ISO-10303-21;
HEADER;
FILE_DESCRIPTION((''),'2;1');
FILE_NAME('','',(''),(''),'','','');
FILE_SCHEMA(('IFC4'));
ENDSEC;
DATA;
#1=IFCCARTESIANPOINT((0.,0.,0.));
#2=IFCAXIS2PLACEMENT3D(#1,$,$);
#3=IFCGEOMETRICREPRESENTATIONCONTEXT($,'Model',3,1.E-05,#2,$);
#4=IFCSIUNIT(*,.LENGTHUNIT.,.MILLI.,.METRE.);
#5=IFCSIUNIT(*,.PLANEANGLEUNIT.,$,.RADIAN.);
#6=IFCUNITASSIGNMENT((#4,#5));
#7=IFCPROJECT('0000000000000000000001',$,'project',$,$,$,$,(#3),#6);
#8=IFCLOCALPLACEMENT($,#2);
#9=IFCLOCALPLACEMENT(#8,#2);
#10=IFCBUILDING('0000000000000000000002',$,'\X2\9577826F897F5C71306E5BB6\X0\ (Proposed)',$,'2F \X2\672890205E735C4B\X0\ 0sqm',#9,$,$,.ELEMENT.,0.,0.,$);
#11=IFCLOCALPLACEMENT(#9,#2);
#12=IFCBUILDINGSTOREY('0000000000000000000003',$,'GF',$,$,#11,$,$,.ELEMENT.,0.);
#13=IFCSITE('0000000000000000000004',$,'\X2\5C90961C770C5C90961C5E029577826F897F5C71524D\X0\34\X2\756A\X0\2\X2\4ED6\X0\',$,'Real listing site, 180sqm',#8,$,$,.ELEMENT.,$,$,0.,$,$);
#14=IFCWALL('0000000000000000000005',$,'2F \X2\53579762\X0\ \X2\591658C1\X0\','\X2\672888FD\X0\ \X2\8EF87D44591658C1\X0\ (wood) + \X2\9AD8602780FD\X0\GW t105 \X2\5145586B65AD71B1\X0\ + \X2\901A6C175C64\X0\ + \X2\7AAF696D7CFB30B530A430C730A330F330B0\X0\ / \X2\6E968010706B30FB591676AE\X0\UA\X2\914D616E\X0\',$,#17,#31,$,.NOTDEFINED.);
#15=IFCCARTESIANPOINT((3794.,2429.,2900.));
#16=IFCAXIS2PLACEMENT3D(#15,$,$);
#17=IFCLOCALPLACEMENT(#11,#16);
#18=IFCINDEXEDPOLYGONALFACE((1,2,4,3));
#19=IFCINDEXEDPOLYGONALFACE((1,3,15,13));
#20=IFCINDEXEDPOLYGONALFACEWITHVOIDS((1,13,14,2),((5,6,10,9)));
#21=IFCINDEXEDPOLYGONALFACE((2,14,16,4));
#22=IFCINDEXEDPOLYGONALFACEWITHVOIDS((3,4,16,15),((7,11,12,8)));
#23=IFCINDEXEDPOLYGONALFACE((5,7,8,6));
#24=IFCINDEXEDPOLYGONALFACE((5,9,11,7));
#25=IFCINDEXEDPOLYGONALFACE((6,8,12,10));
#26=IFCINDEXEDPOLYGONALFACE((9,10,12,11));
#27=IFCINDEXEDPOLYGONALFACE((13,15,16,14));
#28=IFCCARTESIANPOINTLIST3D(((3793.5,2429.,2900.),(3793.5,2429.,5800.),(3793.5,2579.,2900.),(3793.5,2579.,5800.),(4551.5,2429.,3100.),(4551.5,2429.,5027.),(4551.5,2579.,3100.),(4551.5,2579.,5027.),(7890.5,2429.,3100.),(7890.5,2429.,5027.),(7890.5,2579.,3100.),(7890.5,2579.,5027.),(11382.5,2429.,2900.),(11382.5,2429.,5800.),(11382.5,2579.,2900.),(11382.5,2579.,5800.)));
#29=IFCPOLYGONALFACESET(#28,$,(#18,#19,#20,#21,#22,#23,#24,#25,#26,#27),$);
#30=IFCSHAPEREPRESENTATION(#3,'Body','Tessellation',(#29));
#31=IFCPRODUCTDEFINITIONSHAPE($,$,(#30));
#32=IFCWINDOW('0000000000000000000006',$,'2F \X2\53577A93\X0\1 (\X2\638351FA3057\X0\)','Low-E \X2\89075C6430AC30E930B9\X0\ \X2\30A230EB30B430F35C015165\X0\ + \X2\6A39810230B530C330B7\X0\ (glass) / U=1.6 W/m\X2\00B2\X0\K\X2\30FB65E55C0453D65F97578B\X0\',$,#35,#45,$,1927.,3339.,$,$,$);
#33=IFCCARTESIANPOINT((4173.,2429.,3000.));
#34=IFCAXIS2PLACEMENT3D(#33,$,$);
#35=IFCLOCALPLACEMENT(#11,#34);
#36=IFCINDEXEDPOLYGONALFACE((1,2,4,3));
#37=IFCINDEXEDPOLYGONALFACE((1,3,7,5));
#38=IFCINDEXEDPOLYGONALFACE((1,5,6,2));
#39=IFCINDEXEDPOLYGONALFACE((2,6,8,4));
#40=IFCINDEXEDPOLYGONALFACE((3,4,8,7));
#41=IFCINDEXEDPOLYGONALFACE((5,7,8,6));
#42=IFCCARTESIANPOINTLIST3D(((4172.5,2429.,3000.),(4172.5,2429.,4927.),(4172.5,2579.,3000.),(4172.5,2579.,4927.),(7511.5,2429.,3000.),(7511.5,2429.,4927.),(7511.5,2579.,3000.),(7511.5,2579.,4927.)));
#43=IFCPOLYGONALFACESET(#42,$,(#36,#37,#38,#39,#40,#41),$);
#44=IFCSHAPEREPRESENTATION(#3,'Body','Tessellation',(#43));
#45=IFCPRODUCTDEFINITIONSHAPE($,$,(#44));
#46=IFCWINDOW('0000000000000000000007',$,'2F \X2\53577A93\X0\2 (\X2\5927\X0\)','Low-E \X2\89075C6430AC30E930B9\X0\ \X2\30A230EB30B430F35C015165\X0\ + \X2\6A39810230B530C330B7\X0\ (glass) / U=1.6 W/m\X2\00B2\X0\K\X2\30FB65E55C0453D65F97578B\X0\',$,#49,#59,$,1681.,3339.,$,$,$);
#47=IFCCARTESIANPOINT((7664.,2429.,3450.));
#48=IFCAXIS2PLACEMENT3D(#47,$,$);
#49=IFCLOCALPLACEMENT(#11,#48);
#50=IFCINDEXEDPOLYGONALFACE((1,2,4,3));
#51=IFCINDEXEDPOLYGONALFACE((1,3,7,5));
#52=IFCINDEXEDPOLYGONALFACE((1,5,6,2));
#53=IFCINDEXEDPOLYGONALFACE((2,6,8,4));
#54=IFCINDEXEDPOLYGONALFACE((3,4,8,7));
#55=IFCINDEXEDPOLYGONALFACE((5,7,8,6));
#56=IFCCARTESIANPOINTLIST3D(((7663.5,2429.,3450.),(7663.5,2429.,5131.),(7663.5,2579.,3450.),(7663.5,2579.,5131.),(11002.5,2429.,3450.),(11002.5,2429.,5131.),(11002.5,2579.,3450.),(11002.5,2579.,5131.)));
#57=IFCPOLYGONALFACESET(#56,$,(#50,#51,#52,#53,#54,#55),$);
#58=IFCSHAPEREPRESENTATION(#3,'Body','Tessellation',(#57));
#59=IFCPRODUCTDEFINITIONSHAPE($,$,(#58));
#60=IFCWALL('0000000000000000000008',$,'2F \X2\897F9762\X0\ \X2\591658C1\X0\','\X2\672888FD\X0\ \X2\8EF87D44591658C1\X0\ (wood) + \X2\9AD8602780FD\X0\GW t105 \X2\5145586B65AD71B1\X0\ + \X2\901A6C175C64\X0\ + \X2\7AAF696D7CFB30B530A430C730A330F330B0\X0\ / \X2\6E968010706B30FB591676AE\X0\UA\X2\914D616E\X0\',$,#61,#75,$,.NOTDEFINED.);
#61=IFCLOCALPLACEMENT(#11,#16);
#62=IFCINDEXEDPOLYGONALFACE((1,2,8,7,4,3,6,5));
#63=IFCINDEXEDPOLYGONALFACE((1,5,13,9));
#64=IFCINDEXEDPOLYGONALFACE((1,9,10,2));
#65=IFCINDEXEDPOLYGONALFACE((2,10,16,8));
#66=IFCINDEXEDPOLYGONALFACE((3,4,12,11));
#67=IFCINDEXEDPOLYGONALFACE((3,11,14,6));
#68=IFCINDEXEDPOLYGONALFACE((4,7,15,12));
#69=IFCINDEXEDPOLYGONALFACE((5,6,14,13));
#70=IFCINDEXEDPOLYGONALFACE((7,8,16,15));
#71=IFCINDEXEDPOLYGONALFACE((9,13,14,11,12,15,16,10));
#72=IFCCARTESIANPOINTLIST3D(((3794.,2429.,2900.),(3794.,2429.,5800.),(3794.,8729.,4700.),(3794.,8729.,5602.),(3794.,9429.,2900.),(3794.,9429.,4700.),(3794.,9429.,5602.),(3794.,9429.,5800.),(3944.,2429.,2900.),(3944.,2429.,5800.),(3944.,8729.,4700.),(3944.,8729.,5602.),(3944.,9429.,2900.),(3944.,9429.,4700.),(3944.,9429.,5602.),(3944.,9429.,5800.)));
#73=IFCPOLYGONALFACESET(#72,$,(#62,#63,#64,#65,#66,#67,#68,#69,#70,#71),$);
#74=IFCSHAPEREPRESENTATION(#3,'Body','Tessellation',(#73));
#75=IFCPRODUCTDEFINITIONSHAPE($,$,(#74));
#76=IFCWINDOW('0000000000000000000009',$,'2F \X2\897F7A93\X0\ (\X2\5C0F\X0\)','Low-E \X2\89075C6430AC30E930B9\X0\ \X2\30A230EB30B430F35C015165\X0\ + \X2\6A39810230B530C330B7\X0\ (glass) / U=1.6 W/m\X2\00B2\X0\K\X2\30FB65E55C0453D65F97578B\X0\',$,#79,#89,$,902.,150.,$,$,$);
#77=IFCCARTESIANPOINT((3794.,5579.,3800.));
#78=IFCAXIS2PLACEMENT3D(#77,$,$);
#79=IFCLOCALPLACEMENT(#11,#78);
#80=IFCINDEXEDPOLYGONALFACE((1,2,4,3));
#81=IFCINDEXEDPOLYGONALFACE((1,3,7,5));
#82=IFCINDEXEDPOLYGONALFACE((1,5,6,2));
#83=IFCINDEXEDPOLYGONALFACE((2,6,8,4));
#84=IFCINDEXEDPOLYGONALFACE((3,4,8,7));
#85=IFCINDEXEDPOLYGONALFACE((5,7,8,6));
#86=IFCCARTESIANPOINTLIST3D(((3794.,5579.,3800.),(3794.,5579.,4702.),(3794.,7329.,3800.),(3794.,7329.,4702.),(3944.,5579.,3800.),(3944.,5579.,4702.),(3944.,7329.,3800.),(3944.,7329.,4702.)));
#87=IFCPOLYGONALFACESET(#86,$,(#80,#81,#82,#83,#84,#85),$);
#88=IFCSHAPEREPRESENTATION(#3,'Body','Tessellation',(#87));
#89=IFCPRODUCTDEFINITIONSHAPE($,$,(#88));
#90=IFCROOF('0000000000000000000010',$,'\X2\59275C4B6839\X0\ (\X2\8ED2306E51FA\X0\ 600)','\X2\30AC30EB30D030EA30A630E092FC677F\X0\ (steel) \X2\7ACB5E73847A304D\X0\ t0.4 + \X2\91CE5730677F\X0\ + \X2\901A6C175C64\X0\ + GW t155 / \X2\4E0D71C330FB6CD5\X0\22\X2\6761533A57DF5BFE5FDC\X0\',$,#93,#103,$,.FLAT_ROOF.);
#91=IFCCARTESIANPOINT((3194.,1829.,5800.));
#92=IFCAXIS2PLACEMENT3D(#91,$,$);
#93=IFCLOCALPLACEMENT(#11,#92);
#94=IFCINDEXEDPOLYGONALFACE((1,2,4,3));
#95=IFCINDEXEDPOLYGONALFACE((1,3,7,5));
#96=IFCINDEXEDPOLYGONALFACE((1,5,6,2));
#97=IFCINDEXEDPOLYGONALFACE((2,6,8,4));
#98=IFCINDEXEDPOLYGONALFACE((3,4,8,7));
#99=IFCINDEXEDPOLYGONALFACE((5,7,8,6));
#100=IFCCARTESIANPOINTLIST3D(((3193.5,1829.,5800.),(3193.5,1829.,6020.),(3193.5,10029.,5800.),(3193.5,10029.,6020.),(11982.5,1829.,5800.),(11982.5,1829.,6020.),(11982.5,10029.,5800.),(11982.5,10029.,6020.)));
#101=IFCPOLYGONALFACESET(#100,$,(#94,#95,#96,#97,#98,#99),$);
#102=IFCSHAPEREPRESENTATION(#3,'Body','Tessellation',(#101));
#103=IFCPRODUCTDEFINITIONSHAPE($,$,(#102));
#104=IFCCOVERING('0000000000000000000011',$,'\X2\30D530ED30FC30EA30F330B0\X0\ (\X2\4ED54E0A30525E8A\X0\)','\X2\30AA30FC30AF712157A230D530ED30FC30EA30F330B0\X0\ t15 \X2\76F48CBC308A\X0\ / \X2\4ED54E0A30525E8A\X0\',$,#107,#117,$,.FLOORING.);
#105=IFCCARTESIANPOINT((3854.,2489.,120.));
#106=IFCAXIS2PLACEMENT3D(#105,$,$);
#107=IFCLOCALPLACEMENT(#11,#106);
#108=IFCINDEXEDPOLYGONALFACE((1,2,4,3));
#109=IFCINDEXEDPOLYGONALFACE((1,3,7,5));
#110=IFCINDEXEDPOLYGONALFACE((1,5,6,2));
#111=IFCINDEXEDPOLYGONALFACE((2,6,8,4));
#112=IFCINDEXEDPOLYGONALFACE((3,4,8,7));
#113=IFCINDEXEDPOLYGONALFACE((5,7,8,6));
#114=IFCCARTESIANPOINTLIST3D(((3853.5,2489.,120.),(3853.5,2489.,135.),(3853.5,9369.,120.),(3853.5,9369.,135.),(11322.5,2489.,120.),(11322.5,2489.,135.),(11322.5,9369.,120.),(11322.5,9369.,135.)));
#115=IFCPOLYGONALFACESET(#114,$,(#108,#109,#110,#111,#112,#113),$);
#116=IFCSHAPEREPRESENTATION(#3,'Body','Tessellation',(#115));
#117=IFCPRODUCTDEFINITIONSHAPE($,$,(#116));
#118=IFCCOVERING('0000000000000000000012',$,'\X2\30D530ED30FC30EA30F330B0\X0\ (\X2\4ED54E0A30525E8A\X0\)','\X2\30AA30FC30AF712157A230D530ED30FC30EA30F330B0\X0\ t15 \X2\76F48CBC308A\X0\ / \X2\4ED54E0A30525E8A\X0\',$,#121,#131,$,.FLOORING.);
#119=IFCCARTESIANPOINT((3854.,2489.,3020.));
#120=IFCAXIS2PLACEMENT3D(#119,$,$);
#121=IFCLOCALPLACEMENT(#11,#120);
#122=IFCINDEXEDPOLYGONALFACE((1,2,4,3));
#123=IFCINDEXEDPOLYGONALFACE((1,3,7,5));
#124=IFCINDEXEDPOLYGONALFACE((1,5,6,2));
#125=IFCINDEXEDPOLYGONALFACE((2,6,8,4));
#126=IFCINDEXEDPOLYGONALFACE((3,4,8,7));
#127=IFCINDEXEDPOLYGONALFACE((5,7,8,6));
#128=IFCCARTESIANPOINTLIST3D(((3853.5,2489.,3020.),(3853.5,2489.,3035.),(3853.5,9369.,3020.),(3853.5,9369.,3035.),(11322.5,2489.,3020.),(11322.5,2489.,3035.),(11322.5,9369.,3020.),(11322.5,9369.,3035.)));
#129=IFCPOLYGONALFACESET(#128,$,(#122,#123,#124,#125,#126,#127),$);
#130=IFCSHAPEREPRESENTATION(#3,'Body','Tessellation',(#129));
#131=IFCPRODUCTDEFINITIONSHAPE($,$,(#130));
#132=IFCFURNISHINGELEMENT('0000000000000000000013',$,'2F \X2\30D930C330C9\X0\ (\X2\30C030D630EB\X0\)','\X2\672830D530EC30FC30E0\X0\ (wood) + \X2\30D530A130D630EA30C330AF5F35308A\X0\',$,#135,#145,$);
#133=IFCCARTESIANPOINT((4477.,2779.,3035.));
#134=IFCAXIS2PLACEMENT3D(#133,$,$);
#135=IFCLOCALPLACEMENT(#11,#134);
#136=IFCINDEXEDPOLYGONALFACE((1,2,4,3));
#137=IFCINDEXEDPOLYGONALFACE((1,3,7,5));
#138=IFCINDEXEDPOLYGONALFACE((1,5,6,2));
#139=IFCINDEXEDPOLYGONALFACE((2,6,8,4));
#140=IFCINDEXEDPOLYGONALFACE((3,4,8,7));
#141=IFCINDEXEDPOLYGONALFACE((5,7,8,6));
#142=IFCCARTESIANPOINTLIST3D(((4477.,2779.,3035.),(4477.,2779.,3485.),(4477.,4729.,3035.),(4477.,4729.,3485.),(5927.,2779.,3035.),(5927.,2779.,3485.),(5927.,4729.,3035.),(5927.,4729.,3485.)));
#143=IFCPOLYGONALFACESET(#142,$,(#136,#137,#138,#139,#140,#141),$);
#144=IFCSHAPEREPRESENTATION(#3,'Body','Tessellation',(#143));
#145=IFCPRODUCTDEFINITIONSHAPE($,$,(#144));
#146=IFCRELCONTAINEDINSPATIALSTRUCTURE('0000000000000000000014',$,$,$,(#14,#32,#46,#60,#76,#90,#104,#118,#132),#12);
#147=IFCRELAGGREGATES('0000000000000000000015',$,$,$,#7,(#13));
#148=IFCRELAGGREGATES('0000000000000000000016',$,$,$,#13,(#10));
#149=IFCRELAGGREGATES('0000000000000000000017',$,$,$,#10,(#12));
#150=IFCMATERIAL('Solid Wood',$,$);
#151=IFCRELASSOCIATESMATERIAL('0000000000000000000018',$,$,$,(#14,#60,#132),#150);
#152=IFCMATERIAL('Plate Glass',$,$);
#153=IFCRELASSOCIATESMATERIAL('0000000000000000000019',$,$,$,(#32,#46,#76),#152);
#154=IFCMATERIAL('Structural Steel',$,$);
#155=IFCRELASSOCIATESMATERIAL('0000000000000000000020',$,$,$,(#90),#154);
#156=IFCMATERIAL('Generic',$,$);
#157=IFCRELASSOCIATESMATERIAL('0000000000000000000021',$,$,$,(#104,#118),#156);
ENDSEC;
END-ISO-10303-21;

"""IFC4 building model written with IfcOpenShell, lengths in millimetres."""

from ifc_helpers import new_model, si_unit, frame, frame_2d, origin, place, context, project, spatial, rectangle, extrude, material, element, fill, save


model = new_model("IFC4")

# Units and contexts
model_context = context("Model", 3, precision=1e-05, world=origin())
ifc_project = project(units=[si_unit("LENGTHUNIT", "METRE", prefix="MILLI"), si_unit("PLANEANGLEUNIT", "RADIAN")], contexts=[model_context])

# Site, building, storey
site_placement = place(None, origin())
site = spatial("IfcSite", under=ifc_project, at=site_placement, Name="岐阜県岐阜市長良西山前34番2他", ObjectType="Real listing site, 180sqm", CompositionType="ELEMENT", RefElevation=0.0)
building_placement = place(site_placement, origin())
building = spatial("IfcBuilding", under=site, at=building_placement, Name="長良西山の家 (Proposed)", ObjectType="2F 木造平屋 0sqm", CompositionType="ELEMENT", ElevationOfRefHeight=0.0, ElevationOfTerrain=0.0)
storey_placement = place(building_placement, origin())
storey = spatial("IfcBuildingStorey", under=building, at=storey_placement, Name="GF", CompositionType="ELEMENT", Elevation=0.0)

# Shared definitions
ifc_material_1 = material(Name="Solid Wood")

# Shared definitions
ifc_material_2 = material(Name="Plate Glass")

# Wall, openings, windows
wall_1_placement = place(storey_placement, frame((3794.0, 2429.0, 2900.0)))
wall_1 = element("IfcWall", 1, at=wall_1_placement, inside=storey, material=ifc_material_1, Name="2F 南面 外壁", Description="木製 軸組外壁 (wood) + 高性能GW t105 充填断熱 + 通気層 + 窯業系サイディング / 準耐火・外皮UA配慮", PredefinedType="NOTDEFINED", context=model_context, shape_type="SweptSolid", body=[
    extrude(rectangle(XDim=7589.0, YDim=150.0, at=frame_2d((3794.0, 75.0))), frame((3794.0, 2429.0, 2900.0)), (0.0, 0.0, 1.0), 2900.0),
])
opening_1_placement = place(storey_placement, frame((4173.0, 2429.0, 3000.0)))
opening_1 = element("IfcOpeningElement", 2, at=opening_1_placement, cuts=wall_1, PredefinedType="NOTDEFINED", context=model_context, shape_type="SweptSolid", body=[
    extrude(rectangle(XDim=3339.0, YDim=150.0, at=frame_2d((1669.0, 75.0))), frame((4173.0, 2429.0, 3000.0)), (0.0, 0.0, 1.0), 1927.0),
])
opening_2_placement = place(storey_placement, frame((7664.0, 2429.0, 3450.0)))
opening_2 = element("IfcOpeningElement", 3, at=opening_2_placement, cuts=wall_1, PredefinedType="NOTDEFINED", context=model_context, shape_type="SweptSolid", body=[
    extrude(rectangle(XDim=3339.0, YDim=150.0, at=frame_2d((1669.0, 75.0))), frame((7664.0, 2429.0, 3450.0)), (0.0, 0.0, 1.0), 1681.0),
])
window_1_placement = place(storey_placement, frame((4173.0, 2429.0, 3000.0)))
window_1 = element("IfcWindow", 4, at=window_1_placement, inside=storey, material=ifc_material_2, Name="2F 南窓1 (掃出し)", Description="Low-E 複層ガラス アルゴン封入 + 樹脂サッシ (glass) / U=1.6 W/m²K・日射取得型", OverallHeight=1927.0, OverallWidth=3339.0, context=model_context, shape_type="SweptSolid", body=[
    extrude(rectangle(XDim=3339.0, YDim=150.0, at=frame_2d((1669.0, 75.0))), frame((4173.0, 2429.0, 3000.0)), (0.0, 0.0, 1.0), 1927.0),
])
fill(opening_1, window_1)
window_2_placement = place(storey_placement, frame((7664.0, 2429.0, 3450.0)))
window_2 = element("IfcWindow", 5, at=window_2_placement, inside=storey, material=ifc_material_2, Name="2F 南窓2 (大)", Description="Low-E 複層ガラス アルゴン封入 + 樹脂サッシ (glass) / U=1.6 W/m²K・日射取得型", OverallHeight=1681.0, OverallWidth=3339.0, context=model_context, shape_type="SweptSolid", body=[
    extrude(rectangle(XDim=3339.0, YDim=150.0, at=frame_2d((1669.0, 75.0))), frame((7664.0, 2429.0, 3450.0)), (0.0, 0.0, 1.0), 1681.0),
])
fill(opening_2, window_2)

# Wall, opening, window
wall_2_placement = place(storey_placement, frame((3794.0, 2429.0, 2900.0)))
wall_2 = element("IfcWall", 6, at=wall_2_placement, inside=storey, material=ifc_material_1, Name="2F 西面 外壁", Description="木製 軸組外壁 (wood) + 高性能GW t105 充填断熱 + 通気層 + 窯業系サイディング / 準耐火・外皮UA配慮", PredefinedType="NOTDEFINED", context=model_context, shape_type="SweptSolid", body=[
    extrude(rectangle(XDim=150.0, YDim=7000.0, at=frame_2d((75.0, 3500.0))), frame((3794.0, 2429.0, 2900.0)), (0.0, 0.0, 1.0), 2900.0),
])
opening_3_placement = place(storey_placement, frame((3794.0, 5579.0, 3800.0)))
opening_3 = element("IfcOpeningElement", 7, at=opening_3_placement, cuts=wall_2, PredefinedType="NOTDEFINED", context=model_context, shape_type="SweptSolid", body=[
    extrude(rectangle(XDim=150.0, YDim=1750.0, at=frame_2d((75.0, 875.0))), frame((3794.0, 5579.0, 3800.0)), (0.0, 0.0, 1.0), 902.0),
])
window_3_placement = place(storey_placement, frame((3794.0, 5579.0, 3800.0)))
window_3 = element("IfcWindow", 8, at=window_3_placement, inside=storey, material=ifc_material_2, Name="2F 西窓 (小)", Description="Low-E 複層ガラス アルゴン封入 + 樹脂サッシ (glass) / U=1.6 W/m²K・日射取得型", OverallHeight=902.0, OverallWidth=150.0, context=model_context, shape_type="SweptSolid", body=[
    extrude(rectangle(XDim=150.0, YDim=1750.0, at=frame_2d((75.0, 875.0))), frame((3794.0, 5579.0, 3800.0)), (0.0, 0.0, 1.0), 902.0),
])
fill(opening_3, window_3)

# Roof
ifc_material_3 = material(Name="Structural Steel")
roof_placement = place(storey_placement, frame((3194.0, 1829.0, 5800.0)))
element("IfcRoof", 9, at=roof_placement, inside=storey, material=ifc_material_3, Name="大屋根 (軒の出 600)", Description="ガルバリウム鋼板 (steel) 立平葺き t0.4 + 野地板 + 通気層 + GW t155 / 不燃・法22条区域対応", PredefinedType="FLAT_ROOF", context=model_context, shape_type="SweptSolid", body=[
    extrude(rectangle(XDim=8789.0, YDim=8200.0, at=frame_2d((4394.0, 4100.0))), frame((3194.0, 1829.0, 5800.0)), (0.0, 0.0, 1.0), 220.0),
])

# Coverings
ifc_material_4 = material(Name="Generic")
covering_1_placement = place(storey_placement, frame((3854.0, 2489.0, 120.0)))
element("IfcCovering", 10, at=covering_1_placement, inside=storey, material=ifc_material_4, Name="フローリング (仕上げ床)", Description="オーク無垢フローリング t15 直貼り / 仕上げ床", PredefinedType="FLOORING", context=model_context, shape_type="SweptSolid", body=[
    extrude(rectangle(XDim=7469.0, YDim=6880.0, at=frame_2d((3734.0, 3440.0))), frame((3854.0, 2489.0, 120.0)), (0.0, 0.0, 1.0), 15.0),
])
covering_2_placement = place(storey_placement, frame((3854.0, 2489.0, 3020.0)))
element("IfcCovering", 11, at=covering_2_placement, inside=storey, material=ifc_material_4, Name="フローリング (仕上げ床)", Description="オーク無垢フローリング t15 直貼り / 仕上げ床", PredefinedType="FLOORING", context=model_context, shape_type="SweptSolid", body=[
    extrude(rectangle(XDim=7469.0, YDim=6880.0, at=frame_2d((3734.0, 3440.0))), frame((3854.0, 2489.0, 3020.0)), (0.0, 0.0, 1.0), 15.0),
])

# Furnishing element
furnishing_placement = place(storey_placement, frame((4477.0, 2779.0, 3035.0)))
element("IfcFurnishingElement", 12, at=furnishing_placement, inside=storey, material=ifc_material_1, Name="2F ベッド (ダブル)", Description="木フレーム (wood) + ファブリック張り", context=model_context, shape_type="SweptSolid", body=[
    extrude(rectangle(XDim=1450.0, YDim=1950.0, at=frame_2d((725.0, 975.0))), frame((4477.0, 2779.0, 3035.0)), (0.0, 0.0, 1.0), 450.0),
])

save(model, "model.ifc")
